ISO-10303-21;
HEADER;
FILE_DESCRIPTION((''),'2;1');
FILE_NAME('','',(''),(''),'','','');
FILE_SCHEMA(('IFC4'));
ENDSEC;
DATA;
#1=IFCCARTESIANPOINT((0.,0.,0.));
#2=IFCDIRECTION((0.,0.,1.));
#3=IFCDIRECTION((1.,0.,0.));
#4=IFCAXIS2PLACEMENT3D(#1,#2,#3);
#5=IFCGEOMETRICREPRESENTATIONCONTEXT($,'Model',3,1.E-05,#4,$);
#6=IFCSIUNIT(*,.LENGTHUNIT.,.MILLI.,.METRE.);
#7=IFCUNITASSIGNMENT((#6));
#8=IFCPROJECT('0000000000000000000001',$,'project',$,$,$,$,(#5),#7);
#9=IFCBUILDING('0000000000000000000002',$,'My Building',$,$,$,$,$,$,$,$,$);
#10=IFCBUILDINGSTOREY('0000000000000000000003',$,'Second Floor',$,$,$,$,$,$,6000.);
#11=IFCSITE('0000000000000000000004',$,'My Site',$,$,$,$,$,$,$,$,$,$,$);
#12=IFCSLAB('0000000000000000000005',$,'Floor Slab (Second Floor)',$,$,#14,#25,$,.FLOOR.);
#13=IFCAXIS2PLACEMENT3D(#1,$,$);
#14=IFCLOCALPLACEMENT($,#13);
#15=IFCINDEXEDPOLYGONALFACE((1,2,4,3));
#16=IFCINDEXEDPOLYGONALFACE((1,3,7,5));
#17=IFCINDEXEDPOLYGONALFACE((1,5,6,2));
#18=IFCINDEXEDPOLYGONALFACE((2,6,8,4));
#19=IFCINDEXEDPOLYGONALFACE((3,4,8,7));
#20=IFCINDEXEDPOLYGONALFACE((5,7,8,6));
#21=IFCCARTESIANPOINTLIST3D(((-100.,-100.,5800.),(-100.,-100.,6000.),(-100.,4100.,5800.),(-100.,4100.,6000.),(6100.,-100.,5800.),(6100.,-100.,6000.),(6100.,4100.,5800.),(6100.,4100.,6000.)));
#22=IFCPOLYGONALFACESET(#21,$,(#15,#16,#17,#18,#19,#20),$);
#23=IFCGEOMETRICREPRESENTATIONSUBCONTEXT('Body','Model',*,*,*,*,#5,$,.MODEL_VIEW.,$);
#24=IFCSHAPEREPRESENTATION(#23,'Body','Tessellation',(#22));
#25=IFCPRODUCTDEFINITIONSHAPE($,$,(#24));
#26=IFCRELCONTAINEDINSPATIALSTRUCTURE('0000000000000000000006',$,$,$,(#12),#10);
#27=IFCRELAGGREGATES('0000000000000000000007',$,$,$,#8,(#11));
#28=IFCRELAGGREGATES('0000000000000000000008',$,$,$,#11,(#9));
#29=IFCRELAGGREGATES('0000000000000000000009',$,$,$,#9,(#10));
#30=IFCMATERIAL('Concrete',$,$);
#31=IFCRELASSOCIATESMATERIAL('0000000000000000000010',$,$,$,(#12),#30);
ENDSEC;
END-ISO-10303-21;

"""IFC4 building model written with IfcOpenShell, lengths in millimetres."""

from ifc_helpers import new_model, si_unit, frame, origin_with_axes, place, context, subcontext, project, spatial, indexed_curve, outline, extrude, material, element, save


model = new_model("IFC4")

# Units and contexts
model_context = context("Model", 3, precision=1e-05, world=origin_with_axes())
body_context = subcontext(model_context, "Body", "Model", "MODEL_VIEW")
ifc_project = project(units=[si_unit("LENGTHUNIT", "METRE", prefix="MILLI")], contexts=[model_context])

# Site, building, storey
site = spatial("IfcSite", under=ifc_project, Name="My Site")
building = spatial("IfcBuilding", under=site, Name="My Building")
storey = spatial("IfcBuildingStorey", under=building, Name="Second Floor", Elevation=6000.0)

# Slab
ifc_material = material(Name="Concrete")
slab_placement = place(None, frame((0.0, 0.0, 5800.0), z_axis=(0.0, 0.0, 1.0), x_axis=(1.0, 0.0, 0.0)))
element("IfcSlab", 1, at=slab_placement, inside=storey, material=ifc_material, Name="Floor Slab (Second Floor)", PredefinedType="FLOOR", context=body_context, shape_type="SweptSolid", body=[
    extrude(outline(indexed_curve([(-100.0, -100.0), (6100.0, -100.0), (6100.0, 4100.0), (-100.0, 4100.0)])), None, (0.0, 0.0, 1.0), 200.0),
])

save(model, "model.ifc")
